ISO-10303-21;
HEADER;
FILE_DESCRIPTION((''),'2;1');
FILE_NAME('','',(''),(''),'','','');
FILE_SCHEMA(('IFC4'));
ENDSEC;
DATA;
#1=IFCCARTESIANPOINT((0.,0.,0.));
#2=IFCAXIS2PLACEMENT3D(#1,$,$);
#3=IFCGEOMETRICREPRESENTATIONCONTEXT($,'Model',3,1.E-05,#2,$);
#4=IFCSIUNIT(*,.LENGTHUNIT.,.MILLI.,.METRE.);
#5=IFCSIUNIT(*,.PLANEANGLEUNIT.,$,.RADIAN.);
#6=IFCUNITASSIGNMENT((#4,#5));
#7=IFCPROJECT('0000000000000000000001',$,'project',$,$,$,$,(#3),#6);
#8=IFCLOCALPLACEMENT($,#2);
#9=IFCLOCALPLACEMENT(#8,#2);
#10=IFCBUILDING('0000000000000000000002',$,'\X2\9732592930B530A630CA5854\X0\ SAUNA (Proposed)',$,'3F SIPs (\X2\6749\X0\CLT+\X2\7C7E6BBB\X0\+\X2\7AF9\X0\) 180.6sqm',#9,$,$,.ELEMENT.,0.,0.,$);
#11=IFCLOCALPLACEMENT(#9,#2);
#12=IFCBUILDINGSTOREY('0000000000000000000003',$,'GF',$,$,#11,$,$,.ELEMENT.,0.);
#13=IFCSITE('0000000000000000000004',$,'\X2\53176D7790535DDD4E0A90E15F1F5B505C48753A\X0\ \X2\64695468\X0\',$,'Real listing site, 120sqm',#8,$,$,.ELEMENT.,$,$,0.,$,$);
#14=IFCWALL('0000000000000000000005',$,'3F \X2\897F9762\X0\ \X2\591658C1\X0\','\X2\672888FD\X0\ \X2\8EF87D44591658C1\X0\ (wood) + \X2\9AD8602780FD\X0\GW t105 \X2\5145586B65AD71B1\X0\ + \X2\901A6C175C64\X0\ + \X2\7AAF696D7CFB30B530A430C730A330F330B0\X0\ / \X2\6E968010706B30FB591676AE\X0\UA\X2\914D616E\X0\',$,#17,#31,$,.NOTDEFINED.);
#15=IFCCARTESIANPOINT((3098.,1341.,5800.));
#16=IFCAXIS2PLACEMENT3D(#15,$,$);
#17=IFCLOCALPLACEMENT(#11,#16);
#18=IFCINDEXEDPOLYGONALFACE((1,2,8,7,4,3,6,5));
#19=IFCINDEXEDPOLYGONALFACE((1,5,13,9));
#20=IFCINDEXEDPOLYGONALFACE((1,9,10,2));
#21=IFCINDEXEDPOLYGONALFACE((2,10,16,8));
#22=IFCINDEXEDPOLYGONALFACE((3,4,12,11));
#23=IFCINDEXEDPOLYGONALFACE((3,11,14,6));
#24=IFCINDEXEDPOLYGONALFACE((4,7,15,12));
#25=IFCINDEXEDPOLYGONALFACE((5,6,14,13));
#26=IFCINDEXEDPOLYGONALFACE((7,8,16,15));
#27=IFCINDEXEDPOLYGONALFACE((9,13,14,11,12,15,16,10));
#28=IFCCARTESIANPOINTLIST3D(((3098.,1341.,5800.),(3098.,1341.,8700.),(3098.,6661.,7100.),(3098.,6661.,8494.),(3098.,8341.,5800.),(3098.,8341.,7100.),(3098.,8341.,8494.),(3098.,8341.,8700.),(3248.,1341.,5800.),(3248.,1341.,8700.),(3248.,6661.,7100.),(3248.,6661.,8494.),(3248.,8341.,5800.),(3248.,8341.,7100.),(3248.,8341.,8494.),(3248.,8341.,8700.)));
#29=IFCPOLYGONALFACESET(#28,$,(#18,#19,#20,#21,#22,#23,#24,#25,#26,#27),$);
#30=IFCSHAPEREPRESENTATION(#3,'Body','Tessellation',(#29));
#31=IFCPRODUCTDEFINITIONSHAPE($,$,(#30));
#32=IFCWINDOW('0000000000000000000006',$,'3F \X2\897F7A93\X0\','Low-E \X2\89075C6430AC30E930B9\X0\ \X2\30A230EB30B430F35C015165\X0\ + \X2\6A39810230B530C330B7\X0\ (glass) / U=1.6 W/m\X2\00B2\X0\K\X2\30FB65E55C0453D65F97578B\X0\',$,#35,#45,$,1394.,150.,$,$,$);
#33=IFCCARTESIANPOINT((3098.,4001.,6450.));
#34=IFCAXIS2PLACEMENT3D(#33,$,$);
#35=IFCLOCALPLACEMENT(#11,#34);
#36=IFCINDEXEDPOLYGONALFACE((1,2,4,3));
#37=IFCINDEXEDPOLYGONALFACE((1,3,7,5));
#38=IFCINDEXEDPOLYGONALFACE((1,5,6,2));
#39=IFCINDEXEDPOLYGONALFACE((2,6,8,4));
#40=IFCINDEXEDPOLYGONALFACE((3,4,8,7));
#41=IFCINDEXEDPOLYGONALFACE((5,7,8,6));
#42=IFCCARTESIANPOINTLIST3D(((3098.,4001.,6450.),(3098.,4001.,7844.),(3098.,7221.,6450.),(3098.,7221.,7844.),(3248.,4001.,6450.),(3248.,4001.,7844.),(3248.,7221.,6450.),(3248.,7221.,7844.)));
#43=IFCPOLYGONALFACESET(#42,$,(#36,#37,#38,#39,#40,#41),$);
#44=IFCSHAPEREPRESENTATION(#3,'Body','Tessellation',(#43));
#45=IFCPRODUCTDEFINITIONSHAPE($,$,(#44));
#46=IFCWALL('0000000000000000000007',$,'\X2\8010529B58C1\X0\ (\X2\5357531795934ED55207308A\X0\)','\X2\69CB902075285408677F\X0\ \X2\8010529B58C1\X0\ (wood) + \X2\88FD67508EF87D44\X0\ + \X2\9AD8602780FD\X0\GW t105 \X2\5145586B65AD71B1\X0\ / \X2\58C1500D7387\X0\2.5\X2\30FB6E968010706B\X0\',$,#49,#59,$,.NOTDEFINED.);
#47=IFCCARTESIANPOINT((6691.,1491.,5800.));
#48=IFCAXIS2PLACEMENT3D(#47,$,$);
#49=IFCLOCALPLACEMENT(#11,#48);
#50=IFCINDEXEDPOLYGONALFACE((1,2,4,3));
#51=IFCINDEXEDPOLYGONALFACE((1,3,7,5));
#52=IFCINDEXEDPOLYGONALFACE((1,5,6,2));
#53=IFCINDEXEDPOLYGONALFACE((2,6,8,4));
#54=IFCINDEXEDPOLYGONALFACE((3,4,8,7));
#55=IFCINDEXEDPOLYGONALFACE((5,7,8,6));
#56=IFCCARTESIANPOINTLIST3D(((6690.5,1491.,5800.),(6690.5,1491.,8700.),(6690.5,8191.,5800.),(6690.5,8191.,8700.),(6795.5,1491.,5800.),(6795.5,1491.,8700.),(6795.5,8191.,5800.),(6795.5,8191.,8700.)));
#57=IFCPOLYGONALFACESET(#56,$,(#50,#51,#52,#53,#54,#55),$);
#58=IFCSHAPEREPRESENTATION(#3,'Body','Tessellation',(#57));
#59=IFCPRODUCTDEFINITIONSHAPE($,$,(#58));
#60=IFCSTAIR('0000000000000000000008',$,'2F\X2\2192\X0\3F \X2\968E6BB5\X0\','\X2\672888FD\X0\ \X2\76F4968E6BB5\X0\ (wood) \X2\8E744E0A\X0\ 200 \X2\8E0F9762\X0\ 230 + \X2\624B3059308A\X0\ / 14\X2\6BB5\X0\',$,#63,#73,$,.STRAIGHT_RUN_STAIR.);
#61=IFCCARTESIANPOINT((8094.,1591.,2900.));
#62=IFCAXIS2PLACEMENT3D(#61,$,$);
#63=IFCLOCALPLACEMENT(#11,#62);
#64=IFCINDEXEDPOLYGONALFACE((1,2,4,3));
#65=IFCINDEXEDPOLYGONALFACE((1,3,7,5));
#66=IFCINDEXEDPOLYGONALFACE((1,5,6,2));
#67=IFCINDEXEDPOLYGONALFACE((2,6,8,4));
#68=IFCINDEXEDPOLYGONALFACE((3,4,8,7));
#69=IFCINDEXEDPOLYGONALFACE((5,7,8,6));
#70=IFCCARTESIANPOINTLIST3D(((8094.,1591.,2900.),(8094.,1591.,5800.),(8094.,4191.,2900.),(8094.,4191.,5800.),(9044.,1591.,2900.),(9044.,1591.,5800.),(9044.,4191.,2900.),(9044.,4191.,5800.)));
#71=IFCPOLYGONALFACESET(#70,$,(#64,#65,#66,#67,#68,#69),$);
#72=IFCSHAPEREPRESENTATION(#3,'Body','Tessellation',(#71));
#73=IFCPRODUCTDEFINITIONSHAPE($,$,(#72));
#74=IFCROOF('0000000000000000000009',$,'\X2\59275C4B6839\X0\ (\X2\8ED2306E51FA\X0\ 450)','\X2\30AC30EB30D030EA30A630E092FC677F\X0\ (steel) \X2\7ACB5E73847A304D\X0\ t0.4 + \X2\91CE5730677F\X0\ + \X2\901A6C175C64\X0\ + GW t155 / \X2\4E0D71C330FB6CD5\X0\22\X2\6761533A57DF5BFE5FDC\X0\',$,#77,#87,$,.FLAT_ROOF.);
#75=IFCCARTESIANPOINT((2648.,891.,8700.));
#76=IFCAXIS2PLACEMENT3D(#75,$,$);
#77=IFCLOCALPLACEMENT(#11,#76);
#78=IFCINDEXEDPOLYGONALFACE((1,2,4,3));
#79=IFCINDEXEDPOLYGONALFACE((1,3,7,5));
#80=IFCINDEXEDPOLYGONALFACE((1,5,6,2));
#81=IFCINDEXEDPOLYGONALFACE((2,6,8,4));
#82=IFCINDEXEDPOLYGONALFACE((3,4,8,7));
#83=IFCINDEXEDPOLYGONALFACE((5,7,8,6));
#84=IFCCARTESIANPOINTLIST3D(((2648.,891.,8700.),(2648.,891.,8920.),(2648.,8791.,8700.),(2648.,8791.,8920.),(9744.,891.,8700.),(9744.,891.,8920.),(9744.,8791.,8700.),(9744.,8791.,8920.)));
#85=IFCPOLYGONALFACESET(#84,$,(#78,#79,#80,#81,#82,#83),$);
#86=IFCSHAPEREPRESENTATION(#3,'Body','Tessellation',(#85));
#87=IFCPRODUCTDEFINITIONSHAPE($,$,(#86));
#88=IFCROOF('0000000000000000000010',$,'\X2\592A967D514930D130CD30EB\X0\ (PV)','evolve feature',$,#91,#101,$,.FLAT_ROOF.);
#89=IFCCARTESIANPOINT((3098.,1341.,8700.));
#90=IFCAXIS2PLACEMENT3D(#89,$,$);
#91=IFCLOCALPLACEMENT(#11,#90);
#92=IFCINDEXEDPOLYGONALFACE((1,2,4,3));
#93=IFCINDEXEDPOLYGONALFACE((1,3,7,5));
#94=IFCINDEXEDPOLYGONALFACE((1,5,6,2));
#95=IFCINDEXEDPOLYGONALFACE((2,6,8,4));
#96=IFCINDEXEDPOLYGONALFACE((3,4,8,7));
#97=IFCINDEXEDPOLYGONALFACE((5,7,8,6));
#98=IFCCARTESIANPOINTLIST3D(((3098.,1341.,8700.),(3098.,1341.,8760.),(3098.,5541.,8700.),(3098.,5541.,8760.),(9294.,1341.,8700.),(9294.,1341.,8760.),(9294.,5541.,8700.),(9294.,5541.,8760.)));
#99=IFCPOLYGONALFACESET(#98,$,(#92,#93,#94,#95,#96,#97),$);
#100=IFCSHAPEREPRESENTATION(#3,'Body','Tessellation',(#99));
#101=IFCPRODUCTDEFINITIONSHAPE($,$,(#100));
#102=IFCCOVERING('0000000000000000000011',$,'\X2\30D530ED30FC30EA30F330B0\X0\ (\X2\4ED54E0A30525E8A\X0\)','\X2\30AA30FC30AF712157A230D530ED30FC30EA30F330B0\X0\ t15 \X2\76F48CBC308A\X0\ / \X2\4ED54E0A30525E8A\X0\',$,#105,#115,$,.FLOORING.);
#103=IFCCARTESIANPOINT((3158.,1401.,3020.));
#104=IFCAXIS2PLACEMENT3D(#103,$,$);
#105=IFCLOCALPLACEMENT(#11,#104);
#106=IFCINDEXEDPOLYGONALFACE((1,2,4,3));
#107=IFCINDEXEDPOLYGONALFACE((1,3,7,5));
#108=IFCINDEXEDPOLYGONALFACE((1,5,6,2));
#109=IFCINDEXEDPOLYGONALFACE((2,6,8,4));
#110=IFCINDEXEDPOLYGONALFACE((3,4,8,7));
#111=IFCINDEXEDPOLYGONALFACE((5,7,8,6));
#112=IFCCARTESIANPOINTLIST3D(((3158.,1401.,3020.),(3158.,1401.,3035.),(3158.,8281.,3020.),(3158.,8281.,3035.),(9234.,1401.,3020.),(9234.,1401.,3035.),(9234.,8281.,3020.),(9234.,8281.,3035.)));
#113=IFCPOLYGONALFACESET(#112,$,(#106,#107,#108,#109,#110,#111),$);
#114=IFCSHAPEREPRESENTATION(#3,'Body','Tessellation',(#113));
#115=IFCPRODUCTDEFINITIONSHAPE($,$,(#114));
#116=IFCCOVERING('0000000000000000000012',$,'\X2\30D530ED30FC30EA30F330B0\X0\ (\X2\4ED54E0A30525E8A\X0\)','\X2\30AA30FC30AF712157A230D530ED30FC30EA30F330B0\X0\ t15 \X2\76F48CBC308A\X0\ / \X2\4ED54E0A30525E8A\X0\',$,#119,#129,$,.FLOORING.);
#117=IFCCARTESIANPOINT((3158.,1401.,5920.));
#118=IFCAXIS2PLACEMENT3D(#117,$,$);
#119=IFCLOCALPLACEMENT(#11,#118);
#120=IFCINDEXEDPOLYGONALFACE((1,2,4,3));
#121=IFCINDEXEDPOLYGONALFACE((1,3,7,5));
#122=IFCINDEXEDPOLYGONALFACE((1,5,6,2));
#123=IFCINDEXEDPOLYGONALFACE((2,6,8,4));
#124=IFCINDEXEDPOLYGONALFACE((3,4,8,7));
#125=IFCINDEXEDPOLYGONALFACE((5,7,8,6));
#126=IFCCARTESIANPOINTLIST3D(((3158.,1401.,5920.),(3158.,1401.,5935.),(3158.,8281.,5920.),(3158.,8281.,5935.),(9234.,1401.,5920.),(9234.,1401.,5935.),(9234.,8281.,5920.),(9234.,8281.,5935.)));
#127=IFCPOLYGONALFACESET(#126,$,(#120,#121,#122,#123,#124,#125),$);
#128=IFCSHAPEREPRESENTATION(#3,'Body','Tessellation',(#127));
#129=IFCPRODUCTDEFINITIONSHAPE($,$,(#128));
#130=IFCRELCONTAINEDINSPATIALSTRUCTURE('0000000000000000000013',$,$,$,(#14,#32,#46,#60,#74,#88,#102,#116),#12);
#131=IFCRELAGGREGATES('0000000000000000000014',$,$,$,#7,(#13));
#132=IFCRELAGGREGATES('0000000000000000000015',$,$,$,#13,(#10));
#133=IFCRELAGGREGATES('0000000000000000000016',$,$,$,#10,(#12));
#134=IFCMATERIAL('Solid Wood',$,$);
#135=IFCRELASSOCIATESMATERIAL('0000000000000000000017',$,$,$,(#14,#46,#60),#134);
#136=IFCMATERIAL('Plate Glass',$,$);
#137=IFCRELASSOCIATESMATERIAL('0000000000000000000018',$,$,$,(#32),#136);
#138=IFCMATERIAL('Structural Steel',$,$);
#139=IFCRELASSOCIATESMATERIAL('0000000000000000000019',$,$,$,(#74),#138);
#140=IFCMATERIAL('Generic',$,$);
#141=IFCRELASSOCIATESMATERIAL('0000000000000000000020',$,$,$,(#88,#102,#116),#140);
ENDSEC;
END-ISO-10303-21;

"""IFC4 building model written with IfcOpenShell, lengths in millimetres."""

from ifc_helpers import new_model, si_unit, frame, frame_2d, origin, place, context, project, spatial, rectangle, extrude, material, element, fill, save


model = new_model("IFC4")

# Units and contexts
model_context = context("Model", 3, precision=1e-05, world=origin())
ifc_project = project(units=[si_unit("LENGTHUNIT", "METRE", prefix="MILLI"), si_unit("PLANEANGLEUNIT", "RADIAN")], contexts=[model_context])

# Site, building, storey
site_placement = place(None, origin())
site = spatial("IfcSite", under=ifc_project, at=site_placement, Name="北海道川上郡弟子屈町 摩周", ObjectType="Real listing site, 120sqm", CompositionType="ELEMENT", RefElevation=0.0)
building_placement = place(site_placement, origin())
building = spatial("IfcBuilding", under=site, at=building_placement, Name="露天サウナ塔 SAUNA (Proposed)", ObjectType="3F SIPs (杉CLT+籾殻+竹) 180.6sqm", CompositionType="ELEMENT", ElevationOfRefHeight=0.0, ElevationOfTerrain=0.0)
storey_placement = place(building_placement, origin())
storey = spatial("IfcBuildingStorey", under=building, at=storey_placement, Name="GF", CompositionType="ELEMENT", Elevation=0.0)

# Shared definitions
ifc_material_1 = material(Name="Solid Wood")

# Shared definitions
ifc_material_2 = material(Name="Plate Glass")

# Shared definitions
ifc_material_3 = material(Name="Generic")

# Wall, opening, window
wall_1_placement = place(storey_placement, frame((3098.0, 1341.0, 5800.0)))
wall_1 = element("IfcWall", 1, at=wall_1_placement, inside=storey, material=ifc_material_1, Name="3F 西面 外壁", Description="木製 軸組外壁 (wood) + 高性能GW t105 充填断熱 + 通気層 + 窯業系サイディング / 準耐火・外皮UA配慮", PredefinedType="NOTDEFINED", context=model_context, shape_type="SweptSolid", body=[
    extrude(rectangle(XDim=150.0, YDim=7000.0, at=frame_2d((75.0, 3500.0))), frame((3098.0, 1341.0, 5800.0)), (0.0, 0.0, 1.0), 2900.0),
])
opening_1_placement = place(storey_placement, frame((3098.0, 4001.0, 6450.0)))
opening_1 = element("IfcOpeningElement", 2, at=opening_1_placement, cuts=wall_1, PredefinedType="NOTDEFINED", context=model_context, shape_type="SweptSolid", body=[
    extrude(rectangle(XDim=150.0, YDim=3220.0, at=frame_2d((75.0, 1610.0))), frame((3098.0, 4001.0, 6450.0)), (0.0, 0.0, 1.0), 1394.0),
])
window_1_placement = place(storey_placement, frame((3098.0, 4001.0, 6450.0)))
window_1 = element("IfcWindow", 3, at=window_1_placement, inside=storey, material=ifc_material_2, Name="3F 西窓", Description="Low-E 複層ガラス アルゴン封入 + 樹脂サッシ (glass) / U=1.6 W/m²K・日射取得型", OverallHeight=1394.0, OverallWidth=150.0, context=model_context, shape_type="SweptSolid", body=[
    extrude(rectangle(XDim=150.0, YDim=3220.0, at=frame_2d((75.0, 1610.0))), frame((3098.0, 4001.0, 6450.0)), (0.0, 0.0, 1.0), 1394.0),
])
fill(opening_1, window_1)

# Wall
wall_2_placement = place(storey_placement, frame((6691.0, 1491.0, 5800.0)))
element("IfcWall", 4, at=wall_2_placement, inside=storey, material=ifc_material_1, Name="耐力壁 (南北間仕切り)", Description="構造用合板 耐力壁 (wood) + 製材軸組 + 高性能GW t105 充填断熱 / 壁倍率2.5・準耐火", PredefinedType="NOTDEFINED", context=model_context, shape_type="SweptSolid", body=[
    extrude(rectangle(XDim=105.0, YDim=6700.0, at=frame_2d((52.0, 3350.0))), frame((6691.0, 1491.0, 5800.0)), (0.0, 0.0, 1.0), 2900.0),
])

# Stair
stair_placement = place(storey_placement, frame((8094.0, 1591.0, 2900.0)))
element("IfcStair", 5, at=stair_placement, inside=storey, material=ifc_material_1, Name="2F→3F 階段", Description="木製 直階段 (wood) 蹴上 200 踏面 230 + 手すり / 14段", PredefinedType="STRAIGHT_RUN_STAIR", context=model_context, shape_type="SweptSolid", body=[
    extrude(rectangle(XDim=950.0, YDim=2600.0, at=frame_2d((475.0, 1300.0))), frame((8094.0, 1591.0, 2900.0)), (0.0, 0.0, 1.0), 2900.0),
])

# Roofs
ifc_material_4 = material(Name="Structural Steel")
roof_1_placement = place(storey_placement, frame((2648.0, 891.0, 8700.0)))
element("IfcRoof", 6, at=roof_1_placement, inside=storey, material=ifc_material_4, Name="大屋根 (軒の出 450)", Description="ガルバリウム鋼板 (steel) 立平葺き t0.4 + 野地板 + 通気層 + GW t155 / 不燃・法22条区域対応", PredefinedType="FLAT_ROOF", context=model_context, shape_type="SweptSolid", body=[
    extrude(rectangle(XDim=7096.0, YDim=7900.0, at=frame_2d((3548.0, 3950.0))), frame((2648.0, 891.0, 8700.0)), (0.0, 0.0, 1.0), 220.0),
])
roof_2_placement = place(storey_placement, frame((3098.0, 1341.0, 8700.0)))
element("IfcRoof", 7, at=roof_2_placement, inside=storey, material=ifc_material_3, Name="太陽光パネル (PV)", Description="evolve feature", PredefinedType="FLAT_ROOF", context=model_context, shape_type="SweptSolid", body=[
    extrude(rectangle(XDim=6196.0, YDim=4200.0, at=frame_2d((3098.0, 2100.0))), frame((3098.0, 1341.0, 8700.0)), (0.0, 0.0, 1.0), 60.0),
])

# Coverings
covering_1_placement = place(storey_placement, frame((3158.0, 1401.0, 3020.0)))
element("IfcCovering", 8, at=covering_1_placement, inside=storey, material=ifc_material_3, Name="フローリング (仕上げ床)", Description="オーク無垢フローリング t15 直貼り / 仕上げ床", PredefinedType="FLOORING", context=model_context, shape_type="SweptSolid", body=[
    extrude(rectangle(XDim=6076.0, YDim=6880.0, at=frame_2d((3038.0, 3440.0))), frame((3158.0, 1401.0, 3020.0)), (0.0, 0.0, 1.0), 15.0),
])
covering_2_placement = place(storey_placement, frame((3158.0, 1401.0, 5920.0)))
element("IfcCovering", 9, at=covering_2_placement, inside=storey, material=ifc_material_3, Name="フローリング (仕上げ床)", Description="オーク無垢フローリング t15 直貼り / 仕上げ床", PredefinedType="FLOORING", context=model_context, shape_type="SweptSolid", body=[
    extrude(rectangle(XDim=6076.0, YDim=6880.0, at=frame_2d((3038.0, 3440.0))), frame((3158.0, 1401.0, 5920.0)), (0.0, 0.0, 1.0), 15.0),
])

save(model, "model.ifc")
